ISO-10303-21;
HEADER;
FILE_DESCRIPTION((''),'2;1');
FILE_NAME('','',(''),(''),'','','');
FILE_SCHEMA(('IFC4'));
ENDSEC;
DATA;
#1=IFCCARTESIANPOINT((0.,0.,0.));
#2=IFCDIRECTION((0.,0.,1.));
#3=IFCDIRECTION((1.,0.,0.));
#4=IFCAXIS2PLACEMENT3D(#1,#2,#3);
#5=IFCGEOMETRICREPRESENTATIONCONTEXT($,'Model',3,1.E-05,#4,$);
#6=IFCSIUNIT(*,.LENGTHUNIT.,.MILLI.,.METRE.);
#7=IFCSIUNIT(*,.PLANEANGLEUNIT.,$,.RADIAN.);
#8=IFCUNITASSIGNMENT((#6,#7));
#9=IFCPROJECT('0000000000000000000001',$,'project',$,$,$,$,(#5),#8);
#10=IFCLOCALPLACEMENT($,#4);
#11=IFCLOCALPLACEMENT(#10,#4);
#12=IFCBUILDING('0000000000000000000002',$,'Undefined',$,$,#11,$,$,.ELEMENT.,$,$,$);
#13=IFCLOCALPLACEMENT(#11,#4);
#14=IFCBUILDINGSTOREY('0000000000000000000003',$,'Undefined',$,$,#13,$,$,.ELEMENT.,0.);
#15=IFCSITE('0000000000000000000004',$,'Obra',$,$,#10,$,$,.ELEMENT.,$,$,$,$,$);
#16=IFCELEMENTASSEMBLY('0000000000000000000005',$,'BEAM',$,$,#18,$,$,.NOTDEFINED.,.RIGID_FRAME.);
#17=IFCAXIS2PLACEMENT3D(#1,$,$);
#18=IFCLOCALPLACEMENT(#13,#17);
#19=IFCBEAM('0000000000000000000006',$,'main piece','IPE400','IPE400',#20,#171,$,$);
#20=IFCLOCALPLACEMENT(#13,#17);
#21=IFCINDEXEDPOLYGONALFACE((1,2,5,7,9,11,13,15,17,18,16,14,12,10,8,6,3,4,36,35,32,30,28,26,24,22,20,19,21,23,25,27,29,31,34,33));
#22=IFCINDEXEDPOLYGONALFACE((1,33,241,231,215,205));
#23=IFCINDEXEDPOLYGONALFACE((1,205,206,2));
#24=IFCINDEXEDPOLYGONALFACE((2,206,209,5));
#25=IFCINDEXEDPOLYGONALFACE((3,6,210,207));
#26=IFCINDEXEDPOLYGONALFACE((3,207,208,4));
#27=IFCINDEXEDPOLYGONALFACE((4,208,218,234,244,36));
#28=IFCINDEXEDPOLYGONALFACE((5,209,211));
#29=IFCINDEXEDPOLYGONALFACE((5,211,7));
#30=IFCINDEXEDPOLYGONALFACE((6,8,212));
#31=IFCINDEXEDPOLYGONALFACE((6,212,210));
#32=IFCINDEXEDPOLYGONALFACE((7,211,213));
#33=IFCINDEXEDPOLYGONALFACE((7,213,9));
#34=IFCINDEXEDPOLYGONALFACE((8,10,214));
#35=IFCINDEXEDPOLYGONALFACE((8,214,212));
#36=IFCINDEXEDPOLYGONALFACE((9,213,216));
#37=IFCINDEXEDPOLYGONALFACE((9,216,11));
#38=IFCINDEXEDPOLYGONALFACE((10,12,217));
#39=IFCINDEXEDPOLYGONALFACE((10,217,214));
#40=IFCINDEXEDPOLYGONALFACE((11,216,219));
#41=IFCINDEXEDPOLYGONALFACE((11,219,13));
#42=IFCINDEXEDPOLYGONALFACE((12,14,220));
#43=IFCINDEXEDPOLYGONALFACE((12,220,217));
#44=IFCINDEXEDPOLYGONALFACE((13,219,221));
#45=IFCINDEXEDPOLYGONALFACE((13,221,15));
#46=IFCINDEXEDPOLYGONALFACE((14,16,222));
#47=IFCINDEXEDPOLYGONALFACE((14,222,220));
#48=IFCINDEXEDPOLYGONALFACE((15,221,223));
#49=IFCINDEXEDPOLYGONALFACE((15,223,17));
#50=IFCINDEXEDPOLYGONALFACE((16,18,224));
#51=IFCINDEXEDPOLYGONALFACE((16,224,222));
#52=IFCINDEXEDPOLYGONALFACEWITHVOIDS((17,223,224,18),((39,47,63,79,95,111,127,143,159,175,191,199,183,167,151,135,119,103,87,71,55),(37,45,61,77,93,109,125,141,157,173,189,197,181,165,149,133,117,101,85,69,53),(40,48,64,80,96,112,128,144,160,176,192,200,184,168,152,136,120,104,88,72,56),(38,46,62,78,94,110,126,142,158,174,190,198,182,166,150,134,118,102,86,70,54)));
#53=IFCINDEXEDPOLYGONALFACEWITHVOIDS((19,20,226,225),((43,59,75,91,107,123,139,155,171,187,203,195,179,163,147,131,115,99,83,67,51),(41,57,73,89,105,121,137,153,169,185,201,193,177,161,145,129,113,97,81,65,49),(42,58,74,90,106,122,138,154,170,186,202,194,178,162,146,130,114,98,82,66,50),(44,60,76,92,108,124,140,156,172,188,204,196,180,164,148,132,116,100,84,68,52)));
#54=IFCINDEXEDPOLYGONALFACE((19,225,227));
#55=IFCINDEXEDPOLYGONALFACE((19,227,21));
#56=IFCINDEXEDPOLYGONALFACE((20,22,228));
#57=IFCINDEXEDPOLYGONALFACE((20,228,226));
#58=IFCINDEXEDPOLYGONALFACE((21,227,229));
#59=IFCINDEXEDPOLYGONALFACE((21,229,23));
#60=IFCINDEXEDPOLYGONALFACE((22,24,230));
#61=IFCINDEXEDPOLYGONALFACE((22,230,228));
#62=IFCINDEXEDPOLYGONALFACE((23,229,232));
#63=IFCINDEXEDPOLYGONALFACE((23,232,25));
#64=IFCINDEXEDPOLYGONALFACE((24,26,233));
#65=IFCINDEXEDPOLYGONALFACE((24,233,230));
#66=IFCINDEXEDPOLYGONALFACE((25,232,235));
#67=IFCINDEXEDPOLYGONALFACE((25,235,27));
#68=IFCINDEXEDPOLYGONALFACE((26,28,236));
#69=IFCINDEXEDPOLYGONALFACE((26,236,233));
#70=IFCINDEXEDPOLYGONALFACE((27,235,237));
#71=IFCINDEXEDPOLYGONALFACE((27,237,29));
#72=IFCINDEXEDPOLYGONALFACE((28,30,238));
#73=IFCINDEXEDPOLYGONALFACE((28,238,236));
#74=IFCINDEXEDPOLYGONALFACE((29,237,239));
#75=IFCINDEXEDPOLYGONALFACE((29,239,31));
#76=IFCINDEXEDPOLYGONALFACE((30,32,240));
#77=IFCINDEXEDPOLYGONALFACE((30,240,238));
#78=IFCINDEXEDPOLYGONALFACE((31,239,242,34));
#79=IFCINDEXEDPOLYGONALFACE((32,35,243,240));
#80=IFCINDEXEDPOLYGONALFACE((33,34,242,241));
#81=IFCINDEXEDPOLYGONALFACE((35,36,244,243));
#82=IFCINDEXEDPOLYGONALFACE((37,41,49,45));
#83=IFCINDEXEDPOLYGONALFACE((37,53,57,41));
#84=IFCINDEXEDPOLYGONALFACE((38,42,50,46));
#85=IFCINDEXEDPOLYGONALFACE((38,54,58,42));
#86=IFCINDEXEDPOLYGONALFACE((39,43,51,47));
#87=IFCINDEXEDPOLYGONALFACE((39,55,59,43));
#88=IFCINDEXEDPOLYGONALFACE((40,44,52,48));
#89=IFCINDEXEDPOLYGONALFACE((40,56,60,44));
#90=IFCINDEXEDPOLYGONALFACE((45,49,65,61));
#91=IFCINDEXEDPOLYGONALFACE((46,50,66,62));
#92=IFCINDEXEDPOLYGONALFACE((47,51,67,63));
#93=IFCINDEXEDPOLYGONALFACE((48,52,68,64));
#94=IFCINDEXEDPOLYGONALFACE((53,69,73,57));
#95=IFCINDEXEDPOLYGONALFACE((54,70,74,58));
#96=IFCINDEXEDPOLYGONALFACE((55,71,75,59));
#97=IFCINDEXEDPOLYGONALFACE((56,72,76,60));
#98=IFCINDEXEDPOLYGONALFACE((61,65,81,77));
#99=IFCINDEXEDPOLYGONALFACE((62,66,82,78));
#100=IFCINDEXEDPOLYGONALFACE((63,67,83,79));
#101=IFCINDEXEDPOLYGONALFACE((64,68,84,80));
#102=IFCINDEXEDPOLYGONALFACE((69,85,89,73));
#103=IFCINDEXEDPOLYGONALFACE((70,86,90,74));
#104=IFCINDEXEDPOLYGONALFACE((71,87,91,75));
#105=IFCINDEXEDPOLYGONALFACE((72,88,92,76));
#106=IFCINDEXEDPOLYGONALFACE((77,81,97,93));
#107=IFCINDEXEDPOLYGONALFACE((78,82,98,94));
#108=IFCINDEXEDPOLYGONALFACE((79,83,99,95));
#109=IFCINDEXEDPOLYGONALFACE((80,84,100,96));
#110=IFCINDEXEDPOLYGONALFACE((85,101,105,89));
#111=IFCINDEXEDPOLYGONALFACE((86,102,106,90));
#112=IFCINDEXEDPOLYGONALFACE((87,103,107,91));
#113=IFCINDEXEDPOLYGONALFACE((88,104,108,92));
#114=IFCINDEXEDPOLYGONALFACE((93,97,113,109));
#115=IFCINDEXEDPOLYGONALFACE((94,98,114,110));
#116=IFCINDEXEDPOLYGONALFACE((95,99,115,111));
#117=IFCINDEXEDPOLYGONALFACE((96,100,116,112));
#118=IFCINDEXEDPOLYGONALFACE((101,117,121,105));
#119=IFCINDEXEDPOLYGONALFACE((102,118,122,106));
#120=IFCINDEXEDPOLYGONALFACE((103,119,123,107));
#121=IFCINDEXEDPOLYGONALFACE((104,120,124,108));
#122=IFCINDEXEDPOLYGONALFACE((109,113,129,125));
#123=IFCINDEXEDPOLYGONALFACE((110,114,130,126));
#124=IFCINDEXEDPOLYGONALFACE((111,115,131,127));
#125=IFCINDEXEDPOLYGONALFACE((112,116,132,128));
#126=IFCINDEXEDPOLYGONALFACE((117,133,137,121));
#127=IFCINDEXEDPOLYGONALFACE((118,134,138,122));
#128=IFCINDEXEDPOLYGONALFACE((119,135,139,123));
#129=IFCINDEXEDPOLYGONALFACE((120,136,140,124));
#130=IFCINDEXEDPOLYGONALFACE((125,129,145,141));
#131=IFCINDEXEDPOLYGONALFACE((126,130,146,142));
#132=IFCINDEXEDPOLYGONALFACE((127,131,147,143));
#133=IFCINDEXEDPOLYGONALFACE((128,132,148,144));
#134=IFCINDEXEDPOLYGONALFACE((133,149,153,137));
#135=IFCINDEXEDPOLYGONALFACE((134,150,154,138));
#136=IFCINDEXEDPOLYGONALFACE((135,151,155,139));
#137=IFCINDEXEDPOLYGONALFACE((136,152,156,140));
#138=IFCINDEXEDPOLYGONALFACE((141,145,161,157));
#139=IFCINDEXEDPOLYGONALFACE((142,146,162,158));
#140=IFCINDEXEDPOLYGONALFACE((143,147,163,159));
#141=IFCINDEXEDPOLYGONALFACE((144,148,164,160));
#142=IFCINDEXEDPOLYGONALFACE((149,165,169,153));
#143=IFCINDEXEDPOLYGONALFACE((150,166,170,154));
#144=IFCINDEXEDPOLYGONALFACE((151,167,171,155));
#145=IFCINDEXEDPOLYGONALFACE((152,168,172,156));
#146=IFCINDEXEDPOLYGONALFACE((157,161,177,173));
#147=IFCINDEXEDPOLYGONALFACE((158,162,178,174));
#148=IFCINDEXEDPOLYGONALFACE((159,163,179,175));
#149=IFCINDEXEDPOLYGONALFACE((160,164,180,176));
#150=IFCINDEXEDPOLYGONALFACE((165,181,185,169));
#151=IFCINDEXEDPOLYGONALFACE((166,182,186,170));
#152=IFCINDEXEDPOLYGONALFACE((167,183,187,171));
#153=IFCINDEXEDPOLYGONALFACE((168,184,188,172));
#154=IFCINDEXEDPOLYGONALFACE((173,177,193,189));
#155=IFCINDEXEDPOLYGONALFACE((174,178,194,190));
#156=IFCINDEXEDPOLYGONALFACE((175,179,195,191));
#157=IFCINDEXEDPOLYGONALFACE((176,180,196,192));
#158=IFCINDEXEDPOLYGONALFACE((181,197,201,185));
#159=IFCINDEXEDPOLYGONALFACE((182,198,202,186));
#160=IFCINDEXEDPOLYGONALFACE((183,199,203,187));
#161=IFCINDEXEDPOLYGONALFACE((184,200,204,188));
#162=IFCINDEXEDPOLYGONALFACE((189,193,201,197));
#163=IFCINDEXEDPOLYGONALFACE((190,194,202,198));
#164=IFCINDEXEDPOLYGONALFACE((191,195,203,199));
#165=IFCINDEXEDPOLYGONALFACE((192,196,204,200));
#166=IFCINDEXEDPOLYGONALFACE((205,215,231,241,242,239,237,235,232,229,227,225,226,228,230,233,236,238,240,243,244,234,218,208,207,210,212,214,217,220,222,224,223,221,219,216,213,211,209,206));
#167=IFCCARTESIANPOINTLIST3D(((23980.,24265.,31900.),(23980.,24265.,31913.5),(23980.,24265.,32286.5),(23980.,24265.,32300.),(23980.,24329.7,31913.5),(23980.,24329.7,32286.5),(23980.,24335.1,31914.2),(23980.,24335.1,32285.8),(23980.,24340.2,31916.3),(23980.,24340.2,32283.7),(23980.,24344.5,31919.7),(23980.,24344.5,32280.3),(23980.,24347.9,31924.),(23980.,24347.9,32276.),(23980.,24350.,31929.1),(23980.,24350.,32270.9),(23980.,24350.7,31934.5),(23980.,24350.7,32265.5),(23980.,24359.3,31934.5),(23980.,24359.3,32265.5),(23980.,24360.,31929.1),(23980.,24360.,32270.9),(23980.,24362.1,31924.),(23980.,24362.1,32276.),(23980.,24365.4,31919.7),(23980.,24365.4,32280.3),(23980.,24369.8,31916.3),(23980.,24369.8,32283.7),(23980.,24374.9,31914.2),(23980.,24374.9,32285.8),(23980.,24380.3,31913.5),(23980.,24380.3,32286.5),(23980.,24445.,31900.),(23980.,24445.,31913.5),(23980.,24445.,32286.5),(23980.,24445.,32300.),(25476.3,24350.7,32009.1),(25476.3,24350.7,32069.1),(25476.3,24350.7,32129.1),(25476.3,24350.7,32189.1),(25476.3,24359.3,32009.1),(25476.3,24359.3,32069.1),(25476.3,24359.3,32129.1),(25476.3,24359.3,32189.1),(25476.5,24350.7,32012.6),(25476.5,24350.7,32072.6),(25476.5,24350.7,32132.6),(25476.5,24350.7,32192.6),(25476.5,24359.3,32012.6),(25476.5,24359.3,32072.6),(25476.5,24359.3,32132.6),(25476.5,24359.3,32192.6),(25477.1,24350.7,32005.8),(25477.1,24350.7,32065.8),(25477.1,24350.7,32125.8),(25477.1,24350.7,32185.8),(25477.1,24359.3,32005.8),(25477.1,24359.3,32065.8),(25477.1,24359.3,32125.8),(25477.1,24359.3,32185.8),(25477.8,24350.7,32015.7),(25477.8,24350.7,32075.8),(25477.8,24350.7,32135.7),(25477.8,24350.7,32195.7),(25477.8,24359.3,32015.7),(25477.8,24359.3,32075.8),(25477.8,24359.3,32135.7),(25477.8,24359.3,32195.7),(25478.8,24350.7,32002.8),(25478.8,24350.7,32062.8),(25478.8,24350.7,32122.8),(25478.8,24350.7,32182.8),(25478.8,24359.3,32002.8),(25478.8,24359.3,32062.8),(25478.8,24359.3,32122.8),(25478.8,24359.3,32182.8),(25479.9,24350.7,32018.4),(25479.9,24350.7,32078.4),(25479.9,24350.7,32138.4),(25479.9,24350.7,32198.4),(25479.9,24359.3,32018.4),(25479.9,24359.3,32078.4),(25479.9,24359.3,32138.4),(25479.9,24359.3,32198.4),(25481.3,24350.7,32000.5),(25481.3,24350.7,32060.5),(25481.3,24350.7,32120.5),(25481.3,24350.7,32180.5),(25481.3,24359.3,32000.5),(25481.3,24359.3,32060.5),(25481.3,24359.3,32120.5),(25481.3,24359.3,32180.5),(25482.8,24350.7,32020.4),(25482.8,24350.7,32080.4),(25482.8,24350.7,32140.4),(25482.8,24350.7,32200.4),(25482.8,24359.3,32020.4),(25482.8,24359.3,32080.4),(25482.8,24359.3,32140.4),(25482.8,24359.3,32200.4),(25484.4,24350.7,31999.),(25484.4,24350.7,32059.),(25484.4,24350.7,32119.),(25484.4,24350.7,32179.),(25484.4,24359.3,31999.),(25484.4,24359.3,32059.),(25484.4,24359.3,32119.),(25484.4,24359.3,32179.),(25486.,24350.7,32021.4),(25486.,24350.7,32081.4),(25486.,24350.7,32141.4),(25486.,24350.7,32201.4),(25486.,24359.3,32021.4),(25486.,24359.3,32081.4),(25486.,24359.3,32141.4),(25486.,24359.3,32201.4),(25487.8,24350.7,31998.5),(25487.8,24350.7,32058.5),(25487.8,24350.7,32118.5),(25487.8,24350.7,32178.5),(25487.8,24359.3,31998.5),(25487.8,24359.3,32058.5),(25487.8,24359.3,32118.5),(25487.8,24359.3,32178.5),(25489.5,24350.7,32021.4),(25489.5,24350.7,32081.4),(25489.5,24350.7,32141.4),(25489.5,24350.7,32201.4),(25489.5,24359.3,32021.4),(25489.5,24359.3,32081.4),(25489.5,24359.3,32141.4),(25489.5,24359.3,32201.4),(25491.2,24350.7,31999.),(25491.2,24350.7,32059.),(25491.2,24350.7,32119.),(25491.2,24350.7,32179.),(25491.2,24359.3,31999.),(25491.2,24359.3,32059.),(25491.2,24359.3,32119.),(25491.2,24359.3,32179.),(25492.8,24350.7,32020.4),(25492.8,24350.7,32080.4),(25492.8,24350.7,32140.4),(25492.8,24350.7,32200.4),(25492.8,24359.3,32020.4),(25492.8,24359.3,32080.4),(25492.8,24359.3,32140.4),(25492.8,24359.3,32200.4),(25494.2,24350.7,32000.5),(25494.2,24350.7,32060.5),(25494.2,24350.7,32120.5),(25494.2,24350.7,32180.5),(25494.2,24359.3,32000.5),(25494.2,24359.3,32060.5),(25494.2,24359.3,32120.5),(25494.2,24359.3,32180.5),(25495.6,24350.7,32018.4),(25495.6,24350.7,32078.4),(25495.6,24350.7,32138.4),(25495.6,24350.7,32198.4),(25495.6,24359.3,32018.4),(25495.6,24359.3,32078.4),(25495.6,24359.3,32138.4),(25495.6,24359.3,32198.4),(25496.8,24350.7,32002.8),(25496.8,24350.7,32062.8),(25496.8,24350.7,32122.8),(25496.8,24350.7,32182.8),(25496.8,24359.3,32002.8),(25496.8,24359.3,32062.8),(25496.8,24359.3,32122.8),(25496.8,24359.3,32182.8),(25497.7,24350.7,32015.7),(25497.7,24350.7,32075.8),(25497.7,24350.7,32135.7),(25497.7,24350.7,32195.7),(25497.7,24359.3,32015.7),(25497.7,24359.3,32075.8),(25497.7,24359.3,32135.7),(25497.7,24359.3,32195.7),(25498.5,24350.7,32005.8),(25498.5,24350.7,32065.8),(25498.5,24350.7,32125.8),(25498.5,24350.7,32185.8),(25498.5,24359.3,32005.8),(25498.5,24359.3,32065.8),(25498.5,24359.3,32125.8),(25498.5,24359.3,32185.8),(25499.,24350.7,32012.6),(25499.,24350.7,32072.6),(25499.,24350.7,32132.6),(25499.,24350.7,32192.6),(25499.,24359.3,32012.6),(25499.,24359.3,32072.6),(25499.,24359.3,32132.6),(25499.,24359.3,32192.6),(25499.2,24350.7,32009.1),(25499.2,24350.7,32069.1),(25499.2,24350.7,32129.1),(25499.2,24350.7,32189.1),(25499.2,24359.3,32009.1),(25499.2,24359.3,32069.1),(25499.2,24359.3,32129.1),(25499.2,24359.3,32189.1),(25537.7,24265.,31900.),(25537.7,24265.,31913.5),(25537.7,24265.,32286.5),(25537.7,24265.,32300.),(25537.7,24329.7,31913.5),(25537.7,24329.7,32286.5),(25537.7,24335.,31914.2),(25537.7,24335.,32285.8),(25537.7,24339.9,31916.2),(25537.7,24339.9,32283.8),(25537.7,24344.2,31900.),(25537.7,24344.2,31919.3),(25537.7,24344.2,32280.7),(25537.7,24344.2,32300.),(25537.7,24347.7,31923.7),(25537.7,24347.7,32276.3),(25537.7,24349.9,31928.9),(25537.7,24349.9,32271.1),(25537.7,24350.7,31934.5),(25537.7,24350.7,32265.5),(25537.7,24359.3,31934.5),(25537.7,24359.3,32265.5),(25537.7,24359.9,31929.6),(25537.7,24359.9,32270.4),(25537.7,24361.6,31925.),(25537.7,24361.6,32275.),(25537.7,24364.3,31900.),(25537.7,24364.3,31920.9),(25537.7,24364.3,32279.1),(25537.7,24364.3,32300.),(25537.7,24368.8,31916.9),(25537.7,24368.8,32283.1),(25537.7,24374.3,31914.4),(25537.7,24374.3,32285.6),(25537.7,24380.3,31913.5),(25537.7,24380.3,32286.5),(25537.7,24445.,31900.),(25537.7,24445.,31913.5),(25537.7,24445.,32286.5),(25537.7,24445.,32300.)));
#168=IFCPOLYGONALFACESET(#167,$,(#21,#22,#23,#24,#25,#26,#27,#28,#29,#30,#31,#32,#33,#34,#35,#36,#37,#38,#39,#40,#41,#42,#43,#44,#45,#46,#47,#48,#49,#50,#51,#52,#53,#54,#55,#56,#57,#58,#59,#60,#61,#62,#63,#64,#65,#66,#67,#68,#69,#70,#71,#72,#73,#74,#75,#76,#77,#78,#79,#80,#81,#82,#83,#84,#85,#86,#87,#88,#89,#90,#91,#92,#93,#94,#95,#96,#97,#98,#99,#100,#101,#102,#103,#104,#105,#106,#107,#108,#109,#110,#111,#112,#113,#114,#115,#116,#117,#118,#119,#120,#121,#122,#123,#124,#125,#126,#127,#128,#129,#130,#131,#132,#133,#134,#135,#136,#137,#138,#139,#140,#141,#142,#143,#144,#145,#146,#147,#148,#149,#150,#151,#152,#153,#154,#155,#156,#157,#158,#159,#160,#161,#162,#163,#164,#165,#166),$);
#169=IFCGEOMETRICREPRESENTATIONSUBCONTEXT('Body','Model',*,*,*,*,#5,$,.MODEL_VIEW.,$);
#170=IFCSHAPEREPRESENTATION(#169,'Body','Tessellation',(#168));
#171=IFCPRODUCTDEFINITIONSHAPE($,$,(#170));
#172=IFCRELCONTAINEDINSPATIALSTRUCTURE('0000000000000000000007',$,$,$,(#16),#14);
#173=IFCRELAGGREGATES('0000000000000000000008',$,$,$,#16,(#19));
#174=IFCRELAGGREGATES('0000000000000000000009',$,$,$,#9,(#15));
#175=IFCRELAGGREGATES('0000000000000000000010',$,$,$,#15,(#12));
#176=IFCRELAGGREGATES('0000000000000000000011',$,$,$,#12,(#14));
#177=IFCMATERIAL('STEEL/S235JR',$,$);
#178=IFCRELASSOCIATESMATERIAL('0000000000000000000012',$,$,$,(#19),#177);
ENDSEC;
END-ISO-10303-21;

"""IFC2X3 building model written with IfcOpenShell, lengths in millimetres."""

from ifc_helpers import new_model, si_unit, frame, origin_with_axes, origin_2d_with_axis, place, context, subcontext, project, spatial, rectangle, circle, i_section, extrude, clip, halfspace, source, transform, mapped, material, element, aggregate, save


model = new_model("IFC2X3")

# Units and contexts
model_context = context("Model", 3, precision=1e-05, world=origin_with_axes())
body_context = subcontext(model_context, "Body", "Model", "MODEL_VIEW")
ifc_project = project(units=[si_unit("LENGTHUNIT", "METRE", prefix="MILLI"), si_unit("PLANEANGLEUNIT", "RADIAN")], contexts=[model_context])

# Site, building, storey
site_placement = place(None, origin_with_axes())
site = spatial("IfcSite", under=ifc_project, at=site_placement, Name="Obra", CompositionType="ELEMENT")
building_placement = place(site_placement, origin_with_axes())
building = spatial("IfcBuilding", under=site, at=building_placement, Name="Undefined", CompositionType="ELEMENT")
storey_placement = place(building_placement, origin_with_axes())
storey = spatial("IfcBuildingStorey", under=building, at=storey_placement, Name="Undefined", CompositionType="ELEMENT", Elevation=0.0)

# Shared definitions
ifc_material_1 = material(Name="STEEL/S235JR")

# Element assembly, beam, openings
assembly_1_placement = place(storey_placement, origin_with_axes())
assembly_1 = element("IfcElementAssembly", 1, at=assembly_1_placement, inside=storey, Name="BEAM", AssemblyPlace="NOTDEFINED", PredefinedType="RIGID_FRAME")
beam_1_placement = place(assembly_1_placement, frame((23980.0, 24355.0, 32100.0), z_axis=(0.0, 0.0, 1.0), x_axis=(1.0, 0.000002, 0.0)))
beam_1 = element("IfcBeam", 2, at=beam_1_placement, material=ifc_material_1, Name="main piece", Description="IPE400", ObjectType="IPE400", context=body_context, shape_type="Clipping", body=[
    clip(extrude(i_section(OverallWidth=180.0, OverallDepth=400.0, WebThickness=8.6, FlangeThickness=13.5, FilletRadius=21.0, at=origin_2d_with_axis()), frame((1557.8, 0.0, 0.0), z_axis=(-1.0, 0.0, 0.0), x_axis=(0.0, -1.0, 0.0)), (0.0, 0.0, 1.0), 1557.8), halfspace(frame((1557.8, 0.0, -300.0), z_axis=(-1.0, 0.000002, 0.0), x_axis=(0.000001, 1.0, 0.0)), True)),
])
opening_1_placement = place(assembly_1_placement, frame((23980.0, 24355.0, 32100.0), z_axis=(0.0, 0.0, 1.0), x_axis=(1.0, 0.000002, 0.0)))
element("IfcOpeningElement", 3, at=opening_1_placement, cuts=beam_1, ObjectType="Recess", context=body_context, shape_type="SweptSolid", body=[
    extrude(rectangle(XDim=12.1, YDim=100.3, at=origin_2d_with_axis()), frame((1563.7, -40.9, 201.0), z_axis=(0.0, 0.0, -1.0), x_axis=(-1.0, 0.000002, 0.0)), (0.0, 0.0, 1.0), 402.0),
])
opening_2_placement = place(assembly_1_placement, frame((23980.0, 24355.0, 32100.0), z_axis=(0.0, 0.0, 1.0), x_axis=(1.0, 0.000002, 0.0)))
element("IfcOpeningElement", 4, at=opening_2_placement, cuts=beam_1, ObjectType="Recess", context=body_context, shape_type="SweptSolid", body=[
    extrude(rectangle(XDim=12.1, YDim=101.8, at=origin_2d_with_axis()), frame((1563.7, 40.1, 201.0), z_axis=(0.0, 0.0, -1.0), x_axis=(-1.0, 0.000002, 0.0)), (0.0, 0.0, 1.0), 402.0),
])
shared_shape_1 = source(origin_with_axes(), body_context, "Body", "SweptSolid", [
    extrude(circle(Radius=11.5, at=origin_2d_with_axis()), frame((0.0, -4.4, 0.0), z_axis=(0.0, 1.0, 0.0), x_axis=(1.0, 0.0, 0.0)), (0.0, 0.0, 1.0), 8.8),
])
opening_3_placement = place(assembly_1_placement, frame((25537.8, 24355.0, 32300.0), z_axis=(-1.0, 0.0, 0.0), x_axis=(0.0, 0.0, -1.0)))
element("IfcOpeningElement", 5, at=opening_3_placement, cuts=beam_1, ObjectType="Opening", context=body_context, shape_type="MappedRepresentation", body=[
    mapped(shared_shape_1, transform((110.0, 0.0, 50.0))),
    mapped(shared_shape_1, transform((170.0, 0.0, 50.0))),
    mapped(shared_shape_1, transform((230.0, 0.0, 50.0))),
    mapped(shared_shape_1, transform((290.0, 0.0, 50.0))),
])
aggregate(assembly_1, [beam_1])

save(model, "model.ifc")
